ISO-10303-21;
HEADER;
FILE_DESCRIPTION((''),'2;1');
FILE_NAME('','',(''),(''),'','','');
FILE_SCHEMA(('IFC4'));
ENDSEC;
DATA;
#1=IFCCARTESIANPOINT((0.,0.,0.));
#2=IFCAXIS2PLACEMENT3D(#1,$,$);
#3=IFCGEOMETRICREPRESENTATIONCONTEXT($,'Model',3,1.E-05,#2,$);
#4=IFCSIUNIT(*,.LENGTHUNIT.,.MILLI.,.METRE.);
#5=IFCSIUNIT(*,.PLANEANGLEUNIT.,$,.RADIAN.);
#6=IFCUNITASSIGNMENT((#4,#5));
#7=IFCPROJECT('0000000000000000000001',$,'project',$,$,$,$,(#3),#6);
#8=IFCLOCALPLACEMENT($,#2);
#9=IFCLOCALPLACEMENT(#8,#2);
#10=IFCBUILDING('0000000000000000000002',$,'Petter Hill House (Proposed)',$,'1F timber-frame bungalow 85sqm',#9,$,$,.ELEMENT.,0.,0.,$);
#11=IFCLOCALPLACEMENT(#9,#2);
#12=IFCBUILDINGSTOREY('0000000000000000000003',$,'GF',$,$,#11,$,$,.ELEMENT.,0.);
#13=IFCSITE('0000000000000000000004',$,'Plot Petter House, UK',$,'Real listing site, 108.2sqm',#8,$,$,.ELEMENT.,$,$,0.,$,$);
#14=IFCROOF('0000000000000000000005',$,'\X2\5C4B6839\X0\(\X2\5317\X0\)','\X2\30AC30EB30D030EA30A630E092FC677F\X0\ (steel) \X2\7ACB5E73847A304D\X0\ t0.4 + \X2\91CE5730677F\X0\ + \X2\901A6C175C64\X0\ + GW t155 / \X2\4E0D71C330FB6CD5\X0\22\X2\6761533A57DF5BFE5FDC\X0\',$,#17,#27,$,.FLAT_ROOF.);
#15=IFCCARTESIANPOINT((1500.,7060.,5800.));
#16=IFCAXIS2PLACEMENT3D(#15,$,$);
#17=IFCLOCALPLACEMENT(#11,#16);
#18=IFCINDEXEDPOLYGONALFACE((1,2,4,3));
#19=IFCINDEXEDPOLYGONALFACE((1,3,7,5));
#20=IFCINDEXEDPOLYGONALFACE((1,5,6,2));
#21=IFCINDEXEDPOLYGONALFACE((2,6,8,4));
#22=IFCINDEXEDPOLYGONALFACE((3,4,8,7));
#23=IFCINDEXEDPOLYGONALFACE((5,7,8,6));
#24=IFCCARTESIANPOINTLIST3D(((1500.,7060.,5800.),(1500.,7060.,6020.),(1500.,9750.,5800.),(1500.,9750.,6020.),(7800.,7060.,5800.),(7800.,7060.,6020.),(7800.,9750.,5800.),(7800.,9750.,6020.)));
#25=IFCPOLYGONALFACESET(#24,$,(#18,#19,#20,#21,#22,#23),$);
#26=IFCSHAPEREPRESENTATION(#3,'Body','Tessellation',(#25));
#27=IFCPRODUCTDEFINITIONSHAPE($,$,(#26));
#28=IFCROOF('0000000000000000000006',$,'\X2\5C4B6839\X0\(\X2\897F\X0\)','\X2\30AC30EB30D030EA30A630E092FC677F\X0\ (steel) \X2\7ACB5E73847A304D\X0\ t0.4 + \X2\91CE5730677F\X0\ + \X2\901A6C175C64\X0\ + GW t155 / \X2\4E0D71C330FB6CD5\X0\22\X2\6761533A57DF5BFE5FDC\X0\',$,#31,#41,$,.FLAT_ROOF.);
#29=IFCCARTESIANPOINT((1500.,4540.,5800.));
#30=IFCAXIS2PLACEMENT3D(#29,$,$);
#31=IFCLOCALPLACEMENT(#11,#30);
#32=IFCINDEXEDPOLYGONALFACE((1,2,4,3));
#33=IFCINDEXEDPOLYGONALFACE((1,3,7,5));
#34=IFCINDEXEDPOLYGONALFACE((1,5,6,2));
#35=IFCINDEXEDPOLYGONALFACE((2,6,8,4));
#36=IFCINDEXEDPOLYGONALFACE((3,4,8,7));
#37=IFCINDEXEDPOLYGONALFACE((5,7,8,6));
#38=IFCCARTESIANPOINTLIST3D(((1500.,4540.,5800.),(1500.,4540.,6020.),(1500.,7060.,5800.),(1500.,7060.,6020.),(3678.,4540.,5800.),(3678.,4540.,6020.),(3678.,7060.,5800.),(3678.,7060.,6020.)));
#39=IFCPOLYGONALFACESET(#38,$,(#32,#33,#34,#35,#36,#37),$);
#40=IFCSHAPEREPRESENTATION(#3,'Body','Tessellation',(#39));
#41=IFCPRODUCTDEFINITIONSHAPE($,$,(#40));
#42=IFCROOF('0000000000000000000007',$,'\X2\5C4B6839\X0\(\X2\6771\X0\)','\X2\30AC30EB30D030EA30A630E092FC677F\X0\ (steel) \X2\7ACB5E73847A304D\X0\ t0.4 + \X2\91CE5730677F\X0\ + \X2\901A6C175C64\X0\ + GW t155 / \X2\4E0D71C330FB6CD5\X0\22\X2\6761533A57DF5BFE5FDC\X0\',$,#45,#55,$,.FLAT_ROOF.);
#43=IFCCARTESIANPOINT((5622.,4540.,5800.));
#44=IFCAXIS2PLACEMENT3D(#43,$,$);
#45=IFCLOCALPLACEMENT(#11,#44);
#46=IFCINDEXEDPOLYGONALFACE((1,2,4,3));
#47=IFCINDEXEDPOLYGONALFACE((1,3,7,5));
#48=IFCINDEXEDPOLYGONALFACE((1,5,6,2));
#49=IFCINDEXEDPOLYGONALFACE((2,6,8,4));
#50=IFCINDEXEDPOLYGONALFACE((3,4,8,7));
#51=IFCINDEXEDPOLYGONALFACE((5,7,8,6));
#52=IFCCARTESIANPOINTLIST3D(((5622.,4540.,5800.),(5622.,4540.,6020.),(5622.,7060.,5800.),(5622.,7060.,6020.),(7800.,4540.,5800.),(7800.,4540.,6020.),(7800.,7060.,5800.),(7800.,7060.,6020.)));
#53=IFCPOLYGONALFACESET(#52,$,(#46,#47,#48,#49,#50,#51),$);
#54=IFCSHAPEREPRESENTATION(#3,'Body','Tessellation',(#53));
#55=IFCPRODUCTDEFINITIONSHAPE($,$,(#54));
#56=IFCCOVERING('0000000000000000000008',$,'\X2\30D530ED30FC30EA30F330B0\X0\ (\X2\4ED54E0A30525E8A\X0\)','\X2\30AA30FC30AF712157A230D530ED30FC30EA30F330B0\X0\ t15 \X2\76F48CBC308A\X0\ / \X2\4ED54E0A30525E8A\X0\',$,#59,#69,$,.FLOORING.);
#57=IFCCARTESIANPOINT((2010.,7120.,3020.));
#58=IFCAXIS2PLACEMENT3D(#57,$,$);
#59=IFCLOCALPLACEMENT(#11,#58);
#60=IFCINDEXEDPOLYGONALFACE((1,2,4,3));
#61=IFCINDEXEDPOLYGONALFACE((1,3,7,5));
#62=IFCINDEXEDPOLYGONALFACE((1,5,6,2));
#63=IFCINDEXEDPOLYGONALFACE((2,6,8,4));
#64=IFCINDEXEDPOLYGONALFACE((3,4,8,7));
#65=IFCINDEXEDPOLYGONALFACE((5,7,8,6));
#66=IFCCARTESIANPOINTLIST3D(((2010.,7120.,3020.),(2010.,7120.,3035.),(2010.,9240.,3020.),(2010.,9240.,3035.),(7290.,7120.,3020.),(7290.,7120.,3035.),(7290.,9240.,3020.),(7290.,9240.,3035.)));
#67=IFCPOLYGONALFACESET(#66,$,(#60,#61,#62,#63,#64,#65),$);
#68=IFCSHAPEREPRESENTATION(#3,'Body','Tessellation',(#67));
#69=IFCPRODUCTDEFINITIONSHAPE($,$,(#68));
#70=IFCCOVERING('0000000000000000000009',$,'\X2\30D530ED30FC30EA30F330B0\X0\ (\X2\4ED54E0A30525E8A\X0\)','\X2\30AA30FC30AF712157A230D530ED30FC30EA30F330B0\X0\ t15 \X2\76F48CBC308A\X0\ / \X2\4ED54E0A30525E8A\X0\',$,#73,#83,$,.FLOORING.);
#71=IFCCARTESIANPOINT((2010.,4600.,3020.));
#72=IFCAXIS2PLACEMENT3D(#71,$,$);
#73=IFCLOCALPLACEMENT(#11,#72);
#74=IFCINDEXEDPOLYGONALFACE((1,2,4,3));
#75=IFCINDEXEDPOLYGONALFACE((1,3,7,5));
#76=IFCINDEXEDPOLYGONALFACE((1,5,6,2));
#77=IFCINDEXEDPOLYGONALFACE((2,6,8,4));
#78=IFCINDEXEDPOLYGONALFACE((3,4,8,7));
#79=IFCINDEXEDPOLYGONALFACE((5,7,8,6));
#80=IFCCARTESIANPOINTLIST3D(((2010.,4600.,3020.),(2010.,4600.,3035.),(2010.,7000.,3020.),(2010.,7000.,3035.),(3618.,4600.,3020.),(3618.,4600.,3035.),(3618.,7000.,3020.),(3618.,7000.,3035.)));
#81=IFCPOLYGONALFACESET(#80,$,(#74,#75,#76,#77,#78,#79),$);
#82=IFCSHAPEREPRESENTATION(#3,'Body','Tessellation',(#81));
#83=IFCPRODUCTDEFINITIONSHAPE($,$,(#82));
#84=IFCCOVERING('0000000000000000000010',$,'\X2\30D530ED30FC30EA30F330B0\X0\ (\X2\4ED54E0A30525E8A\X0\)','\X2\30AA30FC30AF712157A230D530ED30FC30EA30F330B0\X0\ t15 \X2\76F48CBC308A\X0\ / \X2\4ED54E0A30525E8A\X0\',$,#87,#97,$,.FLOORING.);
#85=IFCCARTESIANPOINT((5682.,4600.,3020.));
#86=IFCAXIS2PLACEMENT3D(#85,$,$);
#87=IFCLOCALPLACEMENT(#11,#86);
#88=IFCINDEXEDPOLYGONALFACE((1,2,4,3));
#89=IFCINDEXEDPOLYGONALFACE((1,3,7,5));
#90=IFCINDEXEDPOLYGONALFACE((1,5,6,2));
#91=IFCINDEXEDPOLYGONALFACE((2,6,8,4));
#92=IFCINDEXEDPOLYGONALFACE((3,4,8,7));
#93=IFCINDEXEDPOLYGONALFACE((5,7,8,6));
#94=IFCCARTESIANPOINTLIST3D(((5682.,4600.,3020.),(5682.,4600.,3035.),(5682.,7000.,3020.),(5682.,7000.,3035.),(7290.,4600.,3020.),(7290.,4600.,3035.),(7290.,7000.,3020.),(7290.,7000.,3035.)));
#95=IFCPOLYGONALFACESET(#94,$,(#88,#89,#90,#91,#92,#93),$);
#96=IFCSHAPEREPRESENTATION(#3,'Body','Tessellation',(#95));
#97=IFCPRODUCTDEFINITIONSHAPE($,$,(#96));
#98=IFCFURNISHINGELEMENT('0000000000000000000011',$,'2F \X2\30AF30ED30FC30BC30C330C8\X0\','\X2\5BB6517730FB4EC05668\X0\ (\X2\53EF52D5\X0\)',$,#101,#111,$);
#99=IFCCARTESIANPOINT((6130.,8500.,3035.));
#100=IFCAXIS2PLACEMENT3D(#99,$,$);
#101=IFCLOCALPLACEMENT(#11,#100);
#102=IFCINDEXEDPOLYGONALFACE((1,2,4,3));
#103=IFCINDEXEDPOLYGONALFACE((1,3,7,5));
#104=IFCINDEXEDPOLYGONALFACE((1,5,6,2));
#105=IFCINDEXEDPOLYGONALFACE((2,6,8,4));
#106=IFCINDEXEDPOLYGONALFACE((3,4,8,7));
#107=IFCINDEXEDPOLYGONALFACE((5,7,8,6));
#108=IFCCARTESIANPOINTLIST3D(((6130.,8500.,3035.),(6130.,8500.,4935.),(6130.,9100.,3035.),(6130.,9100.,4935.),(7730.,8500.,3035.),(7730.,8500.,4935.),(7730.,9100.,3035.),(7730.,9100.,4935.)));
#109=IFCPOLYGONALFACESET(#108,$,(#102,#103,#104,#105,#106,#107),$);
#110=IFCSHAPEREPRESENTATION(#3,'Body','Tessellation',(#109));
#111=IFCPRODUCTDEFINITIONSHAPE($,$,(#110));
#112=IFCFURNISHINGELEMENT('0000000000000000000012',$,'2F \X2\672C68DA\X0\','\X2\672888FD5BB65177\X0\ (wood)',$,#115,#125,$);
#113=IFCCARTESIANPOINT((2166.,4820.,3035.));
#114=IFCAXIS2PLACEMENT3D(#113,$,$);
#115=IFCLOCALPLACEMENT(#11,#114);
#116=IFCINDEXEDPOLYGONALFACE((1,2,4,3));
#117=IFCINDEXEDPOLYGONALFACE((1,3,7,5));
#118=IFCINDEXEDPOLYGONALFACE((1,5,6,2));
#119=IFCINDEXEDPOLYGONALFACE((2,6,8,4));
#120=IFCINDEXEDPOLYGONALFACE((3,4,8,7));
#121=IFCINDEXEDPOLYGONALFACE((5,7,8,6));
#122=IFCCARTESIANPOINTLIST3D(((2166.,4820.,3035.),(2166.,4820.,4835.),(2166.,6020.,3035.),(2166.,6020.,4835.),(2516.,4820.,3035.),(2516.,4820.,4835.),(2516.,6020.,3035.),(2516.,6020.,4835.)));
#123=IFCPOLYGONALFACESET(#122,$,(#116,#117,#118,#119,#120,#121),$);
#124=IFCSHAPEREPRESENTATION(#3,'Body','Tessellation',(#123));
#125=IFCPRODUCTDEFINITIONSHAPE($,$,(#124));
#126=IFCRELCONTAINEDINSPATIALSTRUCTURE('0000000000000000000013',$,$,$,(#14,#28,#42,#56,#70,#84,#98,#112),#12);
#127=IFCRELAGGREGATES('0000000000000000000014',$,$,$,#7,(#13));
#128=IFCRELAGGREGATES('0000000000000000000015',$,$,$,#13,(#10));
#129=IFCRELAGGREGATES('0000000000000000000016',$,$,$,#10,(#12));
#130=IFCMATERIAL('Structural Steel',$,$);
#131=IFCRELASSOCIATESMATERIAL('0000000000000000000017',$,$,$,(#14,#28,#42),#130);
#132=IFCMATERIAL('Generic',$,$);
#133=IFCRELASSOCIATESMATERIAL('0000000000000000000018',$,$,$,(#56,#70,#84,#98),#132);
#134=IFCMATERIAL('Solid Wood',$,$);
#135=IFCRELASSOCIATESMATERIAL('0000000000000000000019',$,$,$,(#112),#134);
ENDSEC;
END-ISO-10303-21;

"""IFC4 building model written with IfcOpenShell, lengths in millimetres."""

from ifc_helpers import new_model, si_unit, frame, frame_2d, origin, place, context, project, spatial, rectangle, extrude, material, element, save


model = new_model("IFC4")

# Units and contexts
model_context = context("Model", 3, precision=1e-05, world=origin())
ifc_project = project(units=[si_unit("LENGTHUNIT", "METRE", prefix="MILLI"), si_unit("PLANEANGLEUNIT", "RADIAN")], contexts=[model_context])

# Site, building, storey
site_placement = place(None, origin())
site = spatial("IfcSite", under=ifc_project, at=site_placement, Name="Plot Petter House, UK", ObjectType="Real listing site, 108.2sqm", CompositionType="ELEMENT", RefElevation=0.0)
building_placement = place(site_placement, origin())
building = spatial("IfcBuilding", under=site, at=building_placement, Name="Petter Hill House (Proposed)", ObjectType="1F timber-frame bungalow 85sqm", CompositionType="ELEMENT", ElevationOfRefHeight=0.0, ElevationOfTerrain=0.0)
storey_placement = place(building_placement, origin())
storey = spatial("IfcBuildingStorey", under=building, at=storey_placement, Name="GF", CompositionType="ELEMENT", Elevation=0.0)

# Shared definitions
ifc_material_1 = material(Name="Solid Wood")

# Shared definitions
ifc_material_2 = material(Name="Generic")

# Roofs
ifc_material_3 = material(Name="Structural Steel")
for number, where, name in (
    (1, (1500.0, 7060.0, 5800.0), "屋根(北)"),
):
    element("IfcRoof", number, at=place(storey_placement, frame(where)), inside=storey, material=ifc_material_3, Name=name, Description="ガルバリウム鋼板 (steel) 立平葺き t0.4 + 野地板 + 通気層 + GW t155 / 不燃・法22条区域対応", PredefinedType="FLAT_ROOF", context=model_context, shape_type="SweptSolid", body=[
        extrude(rectangle(XDim=6300.0, YDim=2690.0, at=frame_2d((3150.0, 1345.0))), frame((1500.0, 7060.0, 5800.0)), (0.0, 0.0, 1.0), 220.0),
    ])
roof_1_placement = place(storey_placement, frame((1500.0, 4540.0, 5800.0)))
element("IfcRoof", 2, at=roof_1_placement, inside=storey, material=ifc_material_3, Name="屋根(西)", Description="ガルバリウム鋼板 (steel) 立平葺き t0.4 + 野地板 + 通気層 + GW t155 / 不燃・法22条区域対応", PredefinedType="FLAT_ROOF", context=model_context, shape_type="SweptSolid", body=[
    extrude(rectangle(XDim=2178.0, YDim=2520.0, at=frame_2d((1089.0, 1260.0))), frame((1500.0, 4540.0, 5800.0)), (0.0, 0.0, 1.0), 220.0),
])
roof_2_placement = place(storey_placement, frame((5622.0, 4540.0, 5800.0)))
element("IfcRoof", 3, at=roof_2_placement, inside=storey, material=ifc_material_3, Name="屋根(東)", Description="ガルバリウム鋼板 (steel) 立平葺き t0.4 + 野地板 + 通気層 + GW t155 / 不燃・法22条区域対応", PredefinedType="FLAT_ROOF", context=model_context, shape_type="SweptSolid", body=[
    extrude(rectangle(XDim=2178.0, YDim=2520.0, at=frame_2d((1089.0, 1260.0))), frame((5622.0, 4540.0, 5800.0)), (0.0, 0.0, 1.0), 220.0),
])

# Coverings
covering_1_placement = place(storey_placement, frame((2010.0, 7120.0, 3020.0)))
element("IfcCovering", 4, at=covering_1_placement, inside=storey, material=ifc_material_2, Name="フローリング (仕上げ床)", Description="オーク無垢フローリング t15 直貼り / 仕上げ床", PredefinedType="FLOORING", context=model_context, shape_type="SweptSolid", body=[
    extrude(rectangle(XDim=5280.0, YDim=2120.0, at=frame_2d((2640.0, 1060.0))), frame((2010.0, 7120.0, 3020.0)), (0.0, 0.0, 1.0), 15.0),
])
covering_2_placement = place(storey_placement, frame((2010.0, 4600.0, 3020.0)))
element("IfcCovering", 5, at=covering_2_placement, inside=storey, material=ifc_material_2, Name="フローリング (仕上げ床)", Description="オーク無垢フローリング t15 直貼り / 仕上げ床", PredefinedType="FLOORING", context=model_context, shape_type="SweptSolid", body=[
    extrude(rectangle(XDim=1608.0, YDim=2400.0, at=frame_2d((804.0, 1200.0))), frame((2010.0, 4600.0, 3020.0)), (0.0, 0.0, 1.0), 15.0),
])
covering_3_placement = place(storey_placement, frame((5682.0, 4600.0, 3020.0)))
element("IfcCovering", 6, at=covering_3_placement, inside=storey, material=ifc_material_2, Name="フローリング (仕上げ床)", Description="オーク無垢フローリング t15 直貼り / 仕上げ床", PredefinedType="FLOORING", context=model_context, shape_type="SweptSolid", body=[
    extrude(rectangle(XDim=1608.0, YDim=2400.0, at=frame_2d((804.0, 1200.0))), frame((5682.0, 4600.0, 3020.0)), (0.0, 0.0, 1.0), 15.0),
])

# Furnishing elements
furnishing_1_placement = place(storey_placement, frame((6130.0, 8500.0, 3035.0)))
element("IfcFurnishingElement", 7, at=furnishing_1_placement, inside=storey, material=ifc_material_2, Name="2F クローゼット", Description="家具・什器 (可動)", context=model_context, shape_type="SweptSolid", body=[
    extrude(rectangle(XDim=1600.0, YDim=600.0, at=frame_2d((800.0, 300.0))), frame((6130.0, 8500.0, 3035.0)), (0.0, 0.0, 1.0), 1900.0),
])
furnishing_2_placement = place(storey_placement, frame((2166.0, 4820.0, 3035.0)))
element("IfcFurnishingElement", 8, at=furnishing_2_placement, inside=storey, material=ifc_material_1, Name="2F 本棚", Description="木製家具 (wood)", context=model_context, shape_type="SweptSolid", body=[
    extrude(rectangle(XDim=350.0, YDim=1200.0, at=frame_2d((175.0, 600.0))), frame((2166.0, 4820.0, 3035.0)), (0.0, 0.0, 1.0), 1800.0),
])

save(model, "model.ifc")
